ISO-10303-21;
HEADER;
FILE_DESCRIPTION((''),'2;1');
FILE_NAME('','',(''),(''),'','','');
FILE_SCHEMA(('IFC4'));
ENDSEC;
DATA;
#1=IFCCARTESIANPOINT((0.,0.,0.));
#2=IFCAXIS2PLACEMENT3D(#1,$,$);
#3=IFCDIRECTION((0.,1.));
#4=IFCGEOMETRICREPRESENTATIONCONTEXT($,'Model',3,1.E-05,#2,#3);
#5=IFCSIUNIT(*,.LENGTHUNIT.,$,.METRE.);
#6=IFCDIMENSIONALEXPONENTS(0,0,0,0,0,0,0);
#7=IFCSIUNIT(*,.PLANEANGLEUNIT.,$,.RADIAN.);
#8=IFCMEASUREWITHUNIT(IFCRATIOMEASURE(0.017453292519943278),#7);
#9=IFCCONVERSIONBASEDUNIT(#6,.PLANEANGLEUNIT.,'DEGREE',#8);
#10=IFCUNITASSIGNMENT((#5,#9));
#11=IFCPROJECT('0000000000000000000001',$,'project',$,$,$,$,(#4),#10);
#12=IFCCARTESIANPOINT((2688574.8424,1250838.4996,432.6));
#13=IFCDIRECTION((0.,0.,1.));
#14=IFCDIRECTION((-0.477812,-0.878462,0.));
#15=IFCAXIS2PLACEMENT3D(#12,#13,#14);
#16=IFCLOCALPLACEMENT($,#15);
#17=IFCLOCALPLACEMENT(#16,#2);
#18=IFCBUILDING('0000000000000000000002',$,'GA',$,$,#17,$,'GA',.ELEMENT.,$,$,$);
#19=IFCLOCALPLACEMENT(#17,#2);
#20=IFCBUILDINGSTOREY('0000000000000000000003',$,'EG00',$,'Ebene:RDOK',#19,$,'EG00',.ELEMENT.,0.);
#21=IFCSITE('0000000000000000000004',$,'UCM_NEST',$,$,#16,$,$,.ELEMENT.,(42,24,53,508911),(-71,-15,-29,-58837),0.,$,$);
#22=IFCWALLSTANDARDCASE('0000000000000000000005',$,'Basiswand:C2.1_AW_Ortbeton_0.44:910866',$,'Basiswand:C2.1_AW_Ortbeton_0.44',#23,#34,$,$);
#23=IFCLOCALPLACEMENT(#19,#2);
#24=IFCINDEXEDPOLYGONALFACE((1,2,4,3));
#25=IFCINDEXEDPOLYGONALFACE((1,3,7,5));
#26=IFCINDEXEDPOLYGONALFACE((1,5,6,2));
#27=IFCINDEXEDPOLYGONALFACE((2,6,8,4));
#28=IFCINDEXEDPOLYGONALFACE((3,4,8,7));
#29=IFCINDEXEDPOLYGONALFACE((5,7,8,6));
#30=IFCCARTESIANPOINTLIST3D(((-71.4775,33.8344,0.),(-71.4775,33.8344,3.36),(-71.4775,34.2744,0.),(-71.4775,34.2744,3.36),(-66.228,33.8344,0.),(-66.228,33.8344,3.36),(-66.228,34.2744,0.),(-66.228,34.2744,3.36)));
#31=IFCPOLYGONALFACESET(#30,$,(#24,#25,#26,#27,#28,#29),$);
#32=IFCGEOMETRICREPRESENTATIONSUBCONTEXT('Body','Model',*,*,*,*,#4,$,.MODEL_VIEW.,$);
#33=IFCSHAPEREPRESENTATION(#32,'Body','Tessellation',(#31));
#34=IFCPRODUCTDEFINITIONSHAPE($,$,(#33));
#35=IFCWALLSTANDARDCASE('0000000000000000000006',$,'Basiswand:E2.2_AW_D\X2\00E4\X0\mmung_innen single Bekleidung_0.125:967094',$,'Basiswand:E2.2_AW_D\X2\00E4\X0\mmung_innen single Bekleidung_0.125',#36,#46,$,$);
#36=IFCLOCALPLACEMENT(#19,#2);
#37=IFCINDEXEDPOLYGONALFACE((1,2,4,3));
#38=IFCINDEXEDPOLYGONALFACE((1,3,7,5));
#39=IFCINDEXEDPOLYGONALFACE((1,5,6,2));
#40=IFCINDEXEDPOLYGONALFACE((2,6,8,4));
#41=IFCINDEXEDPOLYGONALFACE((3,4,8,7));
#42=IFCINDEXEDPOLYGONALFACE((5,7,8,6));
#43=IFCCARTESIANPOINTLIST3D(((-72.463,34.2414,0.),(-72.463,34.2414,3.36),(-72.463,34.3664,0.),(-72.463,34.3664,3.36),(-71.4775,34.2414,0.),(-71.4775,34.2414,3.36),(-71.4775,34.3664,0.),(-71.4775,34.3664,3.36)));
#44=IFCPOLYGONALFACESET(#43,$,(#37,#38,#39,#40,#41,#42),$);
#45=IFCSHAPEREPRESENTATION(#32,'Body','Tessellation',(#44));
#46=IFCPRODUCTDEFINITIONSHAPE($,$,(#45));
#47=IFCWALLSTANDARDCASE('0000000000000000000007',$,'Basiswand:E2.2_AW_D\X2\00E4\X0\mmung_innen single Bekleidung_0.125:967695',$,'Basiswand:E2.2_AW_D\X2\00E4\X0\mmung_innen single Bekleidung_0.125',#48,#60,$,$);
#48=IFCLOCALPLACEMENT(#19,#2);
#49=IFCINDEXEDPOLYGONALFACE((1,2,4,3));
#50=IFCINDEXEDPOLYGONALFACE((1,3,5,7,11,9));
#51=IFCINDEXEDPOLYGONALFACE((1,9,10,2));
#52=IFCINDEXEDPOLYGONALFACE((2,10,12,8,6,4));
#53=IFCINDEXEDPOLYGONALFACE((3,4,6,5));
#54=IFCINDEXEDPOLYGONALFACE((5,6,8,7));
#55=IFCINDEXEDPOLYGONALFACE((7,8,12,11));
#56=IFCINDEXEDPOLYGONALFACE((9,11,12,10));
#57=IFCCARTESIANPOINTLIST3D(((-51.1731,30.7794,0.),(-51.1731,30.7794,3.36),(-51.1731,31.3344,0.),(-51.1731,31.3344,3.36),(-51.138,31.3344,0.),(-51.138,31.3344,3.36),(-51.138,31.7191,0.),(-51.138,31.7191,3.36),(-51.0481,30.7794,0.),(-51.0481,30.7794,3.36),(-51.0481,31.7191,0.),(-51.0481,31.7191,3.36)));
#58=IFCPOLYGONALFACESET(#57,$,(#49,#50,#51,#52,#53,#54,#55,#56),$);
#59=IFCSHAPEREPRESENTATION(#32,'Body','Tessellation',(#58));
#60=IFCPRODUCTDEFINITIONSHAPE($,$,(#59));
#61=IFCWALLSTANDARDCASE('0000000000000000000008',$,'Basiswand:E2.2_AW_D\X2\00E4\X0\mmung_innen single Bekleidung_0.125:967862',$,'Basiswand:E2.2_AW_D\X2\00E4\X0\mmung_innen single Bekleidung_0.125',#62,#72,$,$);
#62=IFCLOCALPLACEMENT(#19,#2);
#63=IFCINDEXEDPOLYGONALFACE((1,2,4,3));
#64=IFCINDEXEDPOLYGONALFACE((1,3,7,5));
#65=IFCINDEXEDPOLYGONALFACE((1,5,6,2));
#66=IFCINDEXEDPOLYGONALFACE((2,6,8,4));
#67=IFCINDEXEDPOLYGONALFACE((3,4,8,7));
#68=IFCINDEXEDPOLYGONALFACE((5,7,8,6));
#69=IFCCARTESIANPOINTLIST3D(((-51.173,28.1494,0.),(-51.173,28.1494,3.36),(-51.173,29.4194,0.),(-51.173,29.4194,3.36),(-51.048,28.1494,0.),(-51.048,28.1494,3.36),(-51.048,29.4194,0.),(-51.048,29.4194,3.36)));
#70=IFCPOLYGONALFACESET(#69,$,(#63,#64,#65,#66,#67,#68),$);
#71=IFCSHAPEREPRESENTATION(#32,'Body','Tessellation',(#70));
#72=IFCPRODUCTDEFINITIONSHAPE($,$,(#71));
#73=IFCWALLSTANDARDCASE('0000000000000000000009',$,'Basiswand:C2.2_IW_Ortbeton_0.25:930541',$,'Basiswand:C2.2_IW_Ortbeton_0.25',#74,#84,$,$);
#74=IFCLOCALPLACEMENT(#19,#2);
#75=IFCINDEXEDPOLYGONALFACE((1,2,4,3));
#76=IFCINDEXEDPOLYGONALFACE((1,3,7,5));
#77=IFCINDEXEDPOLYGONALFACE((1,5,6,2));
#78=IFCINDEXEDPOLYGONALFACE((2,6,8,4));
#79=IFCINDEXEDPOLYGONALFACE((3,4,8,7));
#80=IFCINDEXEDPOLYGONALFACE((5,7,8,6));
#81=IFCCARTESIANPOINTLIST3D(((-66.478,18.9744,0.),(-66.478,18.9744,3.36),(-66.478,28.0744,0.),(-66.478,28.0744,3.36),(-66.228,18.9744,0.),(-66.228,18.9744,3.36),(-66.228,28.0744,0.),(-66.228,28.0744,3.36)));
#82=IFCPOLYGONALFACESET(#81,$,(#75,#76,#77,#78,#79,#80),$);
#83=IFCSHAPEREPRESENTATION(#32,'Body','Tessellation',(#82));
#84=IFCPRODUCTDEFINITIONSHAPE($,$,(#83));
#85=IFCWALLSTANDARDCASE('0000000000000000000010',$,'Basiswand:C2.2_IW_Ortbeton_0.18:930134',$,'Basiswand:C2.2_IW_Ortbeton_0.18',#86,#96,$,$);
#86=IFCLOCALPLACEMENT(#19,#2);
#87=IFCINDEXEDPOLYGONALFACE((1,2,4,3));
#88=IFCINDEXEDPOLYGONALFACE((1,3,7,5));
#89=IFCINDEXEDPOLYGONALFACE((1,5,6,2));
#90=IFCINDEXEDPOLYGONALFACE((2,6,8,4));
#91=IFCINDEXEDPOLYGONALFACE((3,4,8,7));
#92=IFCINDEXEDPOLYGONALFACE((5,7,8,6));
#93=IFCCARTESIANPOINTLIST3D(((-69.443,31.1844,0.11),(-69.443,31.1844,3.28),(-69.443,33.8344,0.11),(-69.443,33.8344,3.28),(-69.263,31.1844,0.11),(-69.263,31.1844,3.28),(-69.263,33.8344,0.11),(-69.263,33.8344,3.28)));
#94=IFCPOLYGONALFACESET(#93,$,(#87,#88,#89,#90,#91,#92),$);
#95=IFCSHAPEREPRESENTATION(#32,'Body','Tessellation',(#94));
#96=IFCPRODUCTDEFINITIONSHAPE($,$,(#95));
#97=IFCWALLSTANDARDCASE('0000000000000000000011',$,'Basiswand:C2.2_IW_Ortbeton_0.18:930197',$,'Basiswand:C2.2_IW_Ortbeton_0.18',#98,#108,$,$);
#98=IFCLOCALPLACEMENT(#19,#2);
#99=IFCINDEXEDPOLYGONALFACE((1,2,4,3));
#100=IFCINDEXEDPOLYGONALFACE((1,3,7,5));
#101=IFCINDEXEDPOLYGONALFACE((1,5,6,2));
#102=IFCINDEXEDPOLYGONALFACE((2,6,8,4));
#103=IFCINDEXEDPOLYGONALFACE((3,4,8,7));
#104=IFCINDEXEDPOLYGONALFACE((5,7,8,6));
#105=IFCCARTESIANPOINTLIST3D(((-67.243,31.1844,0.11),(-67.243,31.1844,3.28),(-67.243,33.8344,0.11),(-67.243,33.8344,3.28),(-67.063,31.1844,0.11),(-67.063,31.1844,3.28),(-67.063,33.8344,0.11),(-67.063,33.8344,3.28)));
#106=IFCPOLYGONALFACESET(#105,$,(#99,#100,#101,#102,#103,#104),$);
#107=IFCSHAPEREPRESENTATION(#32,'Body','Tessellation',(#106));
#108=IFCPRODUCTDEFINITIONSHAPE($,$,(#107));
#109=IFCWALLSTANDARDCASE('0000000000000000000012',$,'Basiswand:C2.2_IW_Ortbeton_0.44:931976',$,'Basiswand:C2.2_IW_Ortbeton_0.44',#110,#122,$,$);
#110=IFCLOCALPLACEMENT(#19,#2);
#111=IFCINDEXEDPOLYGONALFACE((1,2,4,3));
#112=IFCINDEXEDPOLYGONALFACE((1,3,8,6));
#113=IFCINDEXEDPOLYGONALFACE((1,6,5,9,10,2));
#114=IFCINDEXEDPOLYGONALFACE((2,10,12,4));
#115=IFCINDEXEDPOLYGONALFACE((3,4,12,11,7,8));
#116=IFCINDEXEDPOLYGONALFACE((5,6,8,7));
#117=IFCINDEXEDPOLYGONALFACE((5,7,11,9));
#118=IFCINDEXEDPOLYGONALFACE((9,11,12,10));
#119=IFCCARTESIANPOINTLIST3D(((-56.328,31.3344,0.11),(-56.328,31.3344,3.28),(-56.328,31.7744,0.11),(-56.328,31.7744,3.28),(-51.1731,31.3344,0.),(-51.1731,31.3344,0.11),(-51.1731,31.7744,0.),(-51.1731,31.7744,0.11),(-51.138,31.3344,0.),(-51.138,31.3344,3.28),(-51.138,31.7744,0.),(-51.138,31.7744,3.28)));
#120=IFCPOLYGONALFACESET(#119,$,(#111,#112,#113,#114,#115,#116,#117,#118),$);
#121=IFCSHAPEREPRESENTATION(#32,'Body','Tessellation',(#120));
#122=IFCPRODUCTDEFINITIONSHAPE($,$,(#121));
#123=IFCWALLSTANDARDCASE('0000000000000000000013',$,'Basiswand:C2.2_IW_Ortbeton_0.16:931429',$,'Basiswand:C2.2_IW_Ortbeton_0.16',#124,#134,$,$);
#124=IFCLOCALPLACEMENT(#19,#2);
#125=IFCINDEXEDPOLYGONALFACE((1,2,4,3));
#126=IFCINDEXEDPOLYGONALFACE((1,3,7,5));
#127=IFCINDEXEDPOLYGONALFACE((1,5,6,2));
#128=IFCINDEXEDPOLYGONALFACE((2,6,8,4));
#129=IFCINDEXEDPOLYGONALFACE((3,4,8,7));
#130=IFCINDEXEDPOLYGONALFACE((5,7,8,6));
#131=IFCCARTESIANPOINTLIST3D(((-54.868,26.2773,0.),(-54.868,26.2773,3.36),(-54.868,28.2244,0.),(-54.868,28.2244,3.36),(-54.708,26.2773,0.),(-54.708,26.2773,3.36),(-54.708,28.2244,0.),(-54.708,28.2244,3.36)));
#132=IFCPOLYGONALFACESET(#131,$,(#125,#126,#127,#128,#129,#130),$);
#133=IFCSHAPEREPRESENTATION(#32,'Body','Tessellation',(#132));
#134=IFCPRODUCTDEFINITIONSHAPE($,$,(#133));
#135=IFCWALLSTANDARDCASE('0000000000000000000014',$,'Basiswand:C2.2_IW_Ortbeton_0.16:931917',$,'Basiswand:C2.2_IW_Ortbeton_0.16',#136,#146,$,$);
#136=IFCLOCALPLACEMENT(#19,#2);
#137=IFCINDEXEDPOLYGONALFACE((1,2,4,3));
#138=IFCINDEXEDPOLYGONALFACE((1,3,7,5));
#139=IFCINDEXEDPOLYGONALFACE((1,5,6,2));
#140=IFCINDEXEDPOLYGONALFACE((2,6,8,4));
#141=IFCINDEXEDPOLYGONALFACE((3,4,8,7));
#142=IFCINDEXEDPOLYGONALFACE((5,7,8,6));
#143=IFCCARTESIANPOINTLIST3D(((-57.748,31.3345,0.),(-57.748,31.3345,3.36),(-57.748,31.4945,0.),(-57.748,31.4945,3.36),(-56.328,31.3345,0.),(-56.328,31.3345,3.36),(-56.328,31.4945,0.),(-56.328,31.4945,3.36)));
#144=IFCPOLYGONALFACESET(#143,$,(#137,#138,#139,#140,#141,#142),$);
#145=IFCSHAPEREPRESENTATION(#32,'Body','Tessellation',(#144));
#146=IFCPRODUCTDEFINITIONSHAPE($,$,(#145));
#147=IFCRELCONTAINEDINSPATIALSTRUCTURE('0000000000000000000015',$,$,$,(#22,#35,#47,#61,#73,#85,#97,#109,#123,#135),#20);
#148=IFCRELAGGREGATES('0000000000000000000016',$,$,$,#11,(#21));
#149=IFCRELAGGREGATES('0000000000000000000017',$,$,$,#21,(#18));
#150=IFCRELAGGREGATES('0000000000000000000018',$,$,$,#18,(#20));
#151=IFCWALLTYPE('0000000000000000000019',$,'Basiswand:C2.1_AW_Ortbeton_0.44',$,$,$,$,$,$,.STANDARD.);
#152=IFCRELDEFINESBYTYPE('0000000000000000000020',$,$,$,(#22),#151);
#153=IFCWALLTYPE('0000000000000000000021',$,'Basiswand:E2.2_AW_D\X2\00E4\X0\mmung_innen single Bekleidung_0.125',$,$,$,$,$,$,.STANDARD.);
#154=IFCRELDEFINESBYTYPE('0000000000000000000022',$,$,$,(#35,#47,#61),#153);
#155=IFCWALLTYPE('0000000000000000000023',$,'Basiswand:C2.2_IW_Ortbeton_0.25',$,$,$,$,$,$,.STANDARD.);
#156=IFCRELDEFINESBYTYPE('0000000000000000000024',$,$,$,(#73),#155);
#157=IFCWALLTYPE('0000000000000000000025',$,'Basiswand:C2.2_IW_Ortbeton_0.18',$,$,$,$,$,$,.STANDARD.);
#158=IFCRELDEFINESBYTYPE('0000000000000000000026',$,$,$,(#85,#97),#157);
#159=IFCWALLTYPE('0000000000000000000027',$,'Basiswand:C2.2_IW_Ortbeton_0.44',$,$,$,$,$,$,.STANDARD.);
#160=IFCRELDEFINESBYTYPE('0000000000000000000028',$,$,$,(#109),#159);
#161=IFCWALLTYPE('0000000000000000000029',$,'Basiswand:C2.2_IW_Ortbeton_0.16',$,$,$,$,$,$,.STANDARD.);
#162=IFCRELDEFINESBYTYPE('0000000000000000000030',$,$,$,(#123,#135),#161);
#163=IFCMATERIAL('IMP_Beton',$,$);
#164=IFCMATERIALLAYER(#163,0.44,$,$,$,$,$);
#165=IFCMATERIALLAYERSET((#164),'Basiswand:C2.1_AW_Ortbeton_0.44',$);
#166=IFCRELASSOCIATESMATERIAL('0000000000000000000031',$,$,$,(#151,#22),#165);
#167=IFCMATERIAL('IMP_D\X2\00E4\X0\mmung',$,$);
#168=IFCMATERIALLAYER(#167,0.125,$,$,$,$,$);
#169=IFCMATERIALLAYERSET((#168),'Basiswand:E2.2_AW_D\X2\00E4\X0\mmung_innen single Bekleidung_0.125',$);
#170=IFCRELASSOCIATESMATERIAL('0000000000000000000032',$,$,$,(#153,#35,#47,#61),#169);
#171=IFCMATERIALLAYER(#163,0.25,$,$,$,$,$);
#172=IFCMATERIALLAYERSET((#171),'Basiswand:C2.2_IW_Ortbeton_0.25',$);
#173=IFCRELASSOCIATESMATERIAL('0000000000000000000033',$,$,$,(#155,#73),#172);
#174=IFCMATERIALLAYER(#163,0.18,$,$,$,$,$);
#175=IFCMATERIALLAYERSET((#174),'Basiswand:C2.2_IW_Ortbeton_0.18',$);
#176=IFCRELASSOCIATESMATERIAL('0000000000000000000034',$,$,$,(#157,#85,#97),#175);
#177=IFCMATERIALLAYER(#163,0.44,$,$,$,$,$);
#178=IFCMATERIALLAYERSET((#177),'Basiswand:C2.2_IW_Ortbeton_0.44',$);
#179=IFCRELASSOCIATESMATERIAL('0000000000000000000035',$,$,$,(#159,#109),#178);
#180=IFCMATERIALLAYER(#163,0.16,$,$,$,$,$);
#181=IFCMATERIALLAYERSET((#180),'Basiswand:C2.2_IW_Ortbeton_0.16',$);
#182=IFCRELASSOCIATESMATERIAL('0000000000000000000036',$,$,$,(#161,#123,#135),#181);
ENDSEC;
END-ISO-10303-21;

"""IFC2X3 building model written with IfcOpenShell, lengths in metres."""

from ifc_helpers import new_model, entity, si_unit, converted_unit, direction, frame, frame_2d, origin, place, context, subcontext, project, spatial, polyline, rectangle, extrude, clip, bounded_halfspace, material, layer, layer_set, layer_usage, type_object, element, save


model = new_model("IFC2X3")

# Units and contexts
model_context = context("Model", 3, precision=1e-05, world=origin(), true_north=direction((0.0, 1.0)))
body_context = subcontext(model_context, "Body", "Model", "MODEL_VIEW")
ifc_project = project(units=[si_unit("LENGTHUNIT", "METRE"), converted_unit("PLANEANGLEUNIT", "DEGREE", entity("IfcRatioMeasure", 0.017453292519943278), si_unit("PLANEANGLEUNIT", "RADIAN"), dimensions=[0, 0, 0, 0, 0, 0, 0])], contexts=[model_context])

# Site, building, storey
site_placement = place(None, frame((2688574.8424, 1250838.4996, 432.6), z_axis=(0.0, 0.0, 1.0), x_axis=(-0.477812, -0.878462, 0.0)))
site = spatial("IfcSite", under=ifc_project, at=site_placement, Name="UCM_NEST", CompositionType="ELEMENT", RefLatitude=(42, 24, 53, 508911), RefLongitude=(-71, -15, -29, -58837), RefElevation=0.0)
building_placement = place(site_placement, origin())
building = spatial("IfcBuilding", under=site, at=building_placement, Name="GA", LongName="GA", CompositionType="ELEMENT")
storey_placement = place(building_placement, origin())
storey = spatial("IfcBuildingStorey", under=building, at=storey_placement, Name="EG00", ObjectType="Ebene:RDOK", LongName="EG00", CompositionType="ELEMENT", Elevation=0.0)

# Shared definitions
ifc_material_1 = material(Name="IMP_Dämmung")
ifc_material_2 = material(Name="IMP_Beton")

# Walls
ifc_layer_1 = layer(ifc_material_2, 0.44)
ifc_layer_set_1 = layer_set([ifc_layer_1], Name="Basiswand:C2.1_AW_Ortbeton_0.44")
ifc_layer_usage_1 = layer_usage(ifc_layer_set_1, "AXIS2", "NEGATIVE", 0.22)
wall_type_1 = type_object("IfcWallType", Name="Basiswand:C2.1_AW_Ortbeton_0.44", PredefinedType="STANDARD", material=ifc_layer_set_1)
wall_1_placement = place(storey_placement, frame((-71.4775, 34.0544, 0.0)))
element("IfcWallStandardCase", 1, at=wall_1_placement, inside=storey, type_object=wall_type_1, material=ifc_layer_usage_1, Name="Basiswand:C2.1_AW_Ortbeton_0.44:910866", ObjectType="Basiswand:C2.1_AW_Ortbeton_0.44", context=body_context, shape_type="SweptSolid", body=[
    extrude(rectangle(XDim=5.2494, YDim=0.44, at=frame_2d((2.6247, 0.0), x_axis=(-1.0, 0.0))), origin(), (0.0, 0.0, 1.0), 3.36),
])
ifc_layer_2 = layer(ifc_material_1, 0.125)
ifc_layer_set_2 = layer_set([ifc_layer_2], Name="Basiswand:E2.2_AW_Dämmung_innen single Bekleidung_0.125")
ifc_layer_usage_2 = layer_usage(ifc_layer_set_2, "AXIS2", "NEGATIVE", 0.0625)
wall_type_2 = type_object("IfcWallType", Name="Basiswand:E2.2_AW_Dämmung_innen single Bekleidung_0.125", PredefinedType="STANDARD", material=ifc_layer_set_2)
wall_2_placement = place(storey_placement, frame((-72.463, 34.3039, 0.0)))
element("IfcWallStandardCase", 2, at=wall_2_placement, inside=storey, type_object=wall_type_2, material=ifc_layer_usage_2, Name="Basiswand:E2.2_AW_Dämmung_innen single Bekleidung_0.125:967094", ObjectType="Basiswand:E2.2_AW_Dämmung_innen single Bekleidung_0.125", context=body_context, shape_type="SweptSolid", body=[
    extrude(rectangle(XDim=0.9856, YDim=0.125, at=frame_2d((0.4928, 0.0), x_axis=(-1.0, 0.0))), origin(), (0.0, 0.0, 1.0), 3.36),
])
wall_3_placement = place(storey_placement, frame((-51.1106, 30.7794, 0.0), z_axis=(0.0, 0.0, 1.0), x_axis=(0.0, 1.0, 0.0)))
element("IfcWallStandardCase", 3, at=wall_3_placement, inside=storey, type_object=wall_type_2, material=ifc_layer_usage_2, Name="Basiswand:E2.2_AW_Dämmung_innen single Bekleidung_0.125:967695", ObjectType="Basiswand:E2.2_AW_Dämmung_innen single Bekleidung_0.125", context=body_context, shape_type="Clipping", body=[
    clip(clip(extrude(rectangle(XDim=0.9397, YDim=0.125, at=frame_2d((0.4699, 0.0), x_axis=(-1.0, 0.0))), origin(), (0.0, 0.0, 1.0), 3.36), bounded_halfspace(frame((0.555, 0.0274, 3.36), z_axis=(-1.0, 0.0, 0.0), x_axis=(0.0, -1.0, 0.0)), True, frame((0.555, 0.0274, 3.36), z_axis=(-1.0, 0.0, 0.0), x_axis=(0.0, -1.0, 0.0)), polyline([(0.0, 0.0), (-0.0351, 0.0), (-0.0351, -3.36), (0.0, -3.36), (0.0, 0.0)]))), bounded_halfspace(frame((0.555, 0.0274, 0.0), z_axis=(0.0, -1.0, 0.0), x_axis=(1.0, 0.0, 0.0)), True, frame((0.555, 0.0274, 0.0), z_axis=(0.0, -1.0, 0.0), x_axis=(1.0, 0.0, 0.0)), polyline([(0.0, 0.0), (0.3847, 0.0), (0.3847, 3.36), (0.0, 3.36), (0.0, 0.0)]))),
])
wall_4_placement = place(storey_placement, frame((-51.1105, 29.4194, 0.0), z_axis=(0.0, 0.0, 1.0), x_axis=(0.0, -1.0, 0.0)))
element("IfcWallStandardCase", 4, at=wall_4_placement, inside=storey, type_object=wall_type_2, material=ifc_layer_usage_2, Name="Basiswand:E2.2_AW_Dämmung_innen single Bekleidung_0.125:967862", ObjectType="Basiswand:E2.2_AW_Dämmung_innen single Bekleidung_0.125", context=body_context, shape_type="SweptSolid", body=[
    extrude(rectangle(XDim=1.27, YDim=0.125, at=frame_2d((0.635, 0.0), x_axis=(-1.0, 0.0))), origin(), (0.0, 0.0, 1.0), 3.36),
])
ifc_layer_3 = layer(ifc_material_2, 0.25)
ifc_layer_set_3 = layer_set([ifc_layer_3], Name="Basiswand:C2.2_IW_Ortbeton_0.25")
ifc_layer_usage_3 = layer_usage(ifc_layer_set_3, "AXIS2", "NEGATIVE", 0.125)
wall_type_3 = type_object("IfcWallType", Name="Basiswand:C2.2_IW_Ortbeton_0.25", PredefinedType="STANDARD", material=ifc_layer_set_3)
wall_5_placement = place(storey_placement, frame((-66.353, 28.0744, 0.0), z_axis=(0.0, 0.0, 1.0), x_axis=(0.0, -1.0, 0.0)))
element("IfcWallStandardCase", 5, at=wall_5_placement, inside=storey, type_object=wall_type_3, material=ifc_layer_usage_3, Name="Basiswand:C2.2_IW_Ortbeton_0.25:930541", ObjectType="Basiswand:C2.2_IW_Ortbeton_0.25", context=body_context, shape_type="SweptSolid", body=[
    extrude(rectangle(XDim=9.1, YDim=0.25, at=frame_2d((4.55, 0.0), x_axis=(-1.0, 0.0))), origin(), (0.0, 0.0, 1.0), 3.36),
])
ifc_layer_4 = layer(ifc_material_2, 0.18)
ifc_layer_set_4 = layer_set([ifc_layer_4], Name="Basiswand:C2.2_IW_Ortbeton_0.18")
ifc_layer_usage_4 = layer_usage(ifc_layer_set_4, "AXIS2", "NEGATIVE", 0.09)
wall_type_4 = type_object("IfcWallType", Name="Basiswand:C2.2_IW_Ortbeton_0.18", PredefinedType="STANDARD", material=ifc_layer_set_4)
wall_6_placement = place(storey_placement, frame((-69.353, 31.1844, 0.11), z_axis=(0.0, 0.0, 1.0), x_axis=(0.0, 1.0, 0.0)))
element("IfcWallStandardCase", 6, at=wall_6_placement, inside=storey, type_object=wall_type_4, material=ifc_layer_usage_4, Name="Basiswand:C2.2_IW_Ortbeton_0.18:930134", ObjectType="Basiswand:C2.2_IW_Ortbeton_0.18", context=body_context, shape_type="Clipping", body=[
    clip(clip(extrude(rectangle(XDim=2.65, YDim=0.18, at=frame_2d((1.325, 0.0), x_axis=(-1.0, 0.0))), origin(), (0.0, 0.0, 1.0), 3.17), bounded_halfspace(frame((0.0, -0.09, 3.17), z_axis=(0.0, 0.0, -1.0), x_axis=(0.0, 1.0, 0.0)), True, frame((0.0, -0.09, 3.17), z_axis=(0.0, 0.0, -1.0), x_axis=(0.0, 1.0, 0.0)), polyline([(0.0, 0.0), (0.18, 0.0), (0.18, 2.65), (0.0, 2.65), (0.0, 0.0)]))), bounded_halfspace(frame((2.65, -0.09, 0.0), z_axis=(0.0, 0.0, 1.0), x_axis=(0.0, 1.0, 0.0)), True, frame((2.65, -0.09, 0.0), z_axis=(0.0, 0.0, 1.0), x_axis=(0.0, 1.0, 0.0)), polyline([(0.0, 0.0), (0.18, 0.0), (0.18, 2.65), (0.0, 2.65), (0.0, 0.0)]))),
])
wall_7_placement = place(storey_placement, frame((-67.153, 31.1844, 0.11), z_axis=(0.0, 0.0, 1.0), x_axis=(0.0, 1.0, 0.0)))
element("IfcWallStandardCase", 7, at=wall_7_placement, inside=storey, type_object=wall_type_4, material=ifc_layer_usage_4, Name="Basiswand:C2.2_IW_Ortbeton_0.18:930197", ObjectType="Basiswand:C2.2_IW_Ortbeton_0.18", context=body_context, shape_type="Clipping", body=[
    clip(clip(extrude(rectangle(XDim=2.65, YDim=0.18, at=frame_2d((1.325, 0.0), x_axis=(-1.0, 0.0))), origin(), (0.0, 0.0, 1.0), 3.17), bounded_halfspace(frame((2.65, -0.09, 0.0), z_axis=(0.0, 0.0, 1.0), x_axis=(0.0, 1.0, 0.0)), True, frame((2.65, -0.09, 0.0), z_axis=(0.0, 0.0, 1.0), x_axis=(0.0, 1.0, 0.0)), polyline([(0.0, 0.0), (0.18, 0.0), (0.18, 2.65), (0.0, 2.65), (0.0, 0.0)]))), bounded_halfspace(frame((0.0, -0.09, 3.17), z_axis=(0.0, 0.0, -1.0), x_axis=(0.0, 1.0, 0.0)), True, frame((0.0, -0.09, 3.17), z_axis=(0.0, 0.0, -1.0), x_axis=(0.0, 1.0, 0.0)), polyline([(0.0, 0.0), (0.18, 0.0), (0.18, 2.65), (0.0, 2.65), (0.0, 0.0)]))),
])
ifc_layer_5 = layer(ifc_material_2, 0.44)
ifc_layer_set_5 = layer_set([ifc_layer_5], Name="Basiswand:C2.2_IW_Ortbeton_0.44")
ifc_layer_usage_5 = layer_usage(ifc_layer_set_5, "AXIS2", "NEGATIVE", 0.22)
wall_type_5 = type_object("IfcWallType", Name="Basiswand:C2.2_IW_Ortbeton_0.44", PredefinedType="STANDARD", material=ifc_layer_set_5)
wall_8_placement = place(storey_placement, frame((-56.328, 31.5544, 0.0)))
element("IfcWallStandardCase", 8, at=wall_8_placement, inside=storey, type_object=wall_type_5, material=ifc_layer_usage_5, Name="Basiswand:C2.2_IW_Ortbeton_0.44:931976", ObjectType="Basiswand:C2.2_IW_Ortbeton_0.44", context=body_context, shape_type="Clipping", body=[
    clip(clip(clip(extrude(rectangle(XDim=5.19, YDim=0.44, at=frame_2d((2.595, 0.0), x_axis=(-1.0, 0.0))), origin(), (0.0, 0.0, 1.0), 3.28), bounded_halfspace(frame((5.1549, 0.22, 0.11), z_axis=(0.0, 0.0, 1.0), x_axis=(-1.0, 0.0, 0.0)), True, frame((5.1549, 0.22, 0.11), z_axis=(0.0, 0.0, 1.0), x_axis=(-1.0, 0.0, 0.0)), polyline([(0.0, 0.0), (5.1549, 0.0), (5.1549, 0.44), (0.0, 0.44), (0.0, 0.0)]))), bounded_halfspace(frame((5.1549, -0.22, 0.11), z_axis=(1.0, 0.0, 0.0), x_axis=(0.0, 0.0, 1.0)), True, frame((5.1549, -0.22, 0.11), z_axis=(1.0, 0.0, 0.0), x_axis=(0.0, 0.0, 1.0)), polyline([(0.0, 0.0), (-0.11, 0.0), (-0.11, -0.44), (0.0, -0.44), (0.0, 0.0)]))), bounded_halfspace(frame((0.0, -0.22, 3.28), z_axis=(0.0, 0.0, -1.0), x_axis=(-1.0, 0.0, 0.0)), True, frame((0.0, -0.22, 3.28), z_axis=(0.0, 0.0, -1.0), x_axis=(-1.0, 0.0, 0.0)), polyline([(0.0, 0.0), (0.0, 0.44), (-5.19, 0.44), (-5.19, 0.0), (0.0, 0.0)]))),
])
ifc_layer_6 = layer(ifc_material_2, 0.16)
ifc_layer_set_6 = layer_set([ifc_layer_6], Name="Basiswand:C2.2_IW_Ortbeton_0.16")
ifc_layer_usage_6 = layer_usage(ifc_layer_set_6, "AXIS2", "NEGATIVE", 0.08)
wall_type_6 = type_object("IfcWallType", Name="Basiswand:C2.2_IW_Ortbeton_0.16", PredefinedType="STANDARD", material=ifc_layer_set_6)
wall_9_placement = place(storey_placement, frame((-54.788, 28.2244, 0.0), z_axis=(0.0, 0.0, 1.0), x_axis=(0.0, -1.0, 0.0)))
element("IfcWallStandardCase", 9, at=wall_9_placement, inside=storey, type_object=wall_type_6, material=ifc_layer_usage_6, Name="Basiswand:C2.2_IW_Ortbeton_0.16:931429", ObjectType="Basiswand:C2.2_IW_Ortbeton_0.16", context=body_context, shape_type="SweptSolid", body=[
    extrude(rectangle(XDim=1.9471, YDim=0.16, at=frame_2d((0.9736, 0.0), x_axis=(-1.0, 0.0))), origin(), (0.0, 0.0, 1.0), 3.36),
])
wall_10_placement = place(storey_placement, frame((-57.748, 31.4145, 0.0)))
element("IfcWallStandardCase", 10, at=wall_10_placement, inside=storey, type_object=wall_type_6, material=ifc_layer_usage_6, Name="Basiswand:C2.2_IW_Ortbeton_0.16:931917", ObjectType="Basiswand:C2.2_IW_Ortbeton_0.16", context=body_context, shape_type="SweptSolid", body=[
    extrude(rectangle(XDim=1.42, YDim=0.16, at=frame_2d((0.71, 0.0), x_axis=(-1.0, 0.0))), origin(), (0.0, 0.0, 1.0), 3.36),
])

save(model, "model.ifc")
